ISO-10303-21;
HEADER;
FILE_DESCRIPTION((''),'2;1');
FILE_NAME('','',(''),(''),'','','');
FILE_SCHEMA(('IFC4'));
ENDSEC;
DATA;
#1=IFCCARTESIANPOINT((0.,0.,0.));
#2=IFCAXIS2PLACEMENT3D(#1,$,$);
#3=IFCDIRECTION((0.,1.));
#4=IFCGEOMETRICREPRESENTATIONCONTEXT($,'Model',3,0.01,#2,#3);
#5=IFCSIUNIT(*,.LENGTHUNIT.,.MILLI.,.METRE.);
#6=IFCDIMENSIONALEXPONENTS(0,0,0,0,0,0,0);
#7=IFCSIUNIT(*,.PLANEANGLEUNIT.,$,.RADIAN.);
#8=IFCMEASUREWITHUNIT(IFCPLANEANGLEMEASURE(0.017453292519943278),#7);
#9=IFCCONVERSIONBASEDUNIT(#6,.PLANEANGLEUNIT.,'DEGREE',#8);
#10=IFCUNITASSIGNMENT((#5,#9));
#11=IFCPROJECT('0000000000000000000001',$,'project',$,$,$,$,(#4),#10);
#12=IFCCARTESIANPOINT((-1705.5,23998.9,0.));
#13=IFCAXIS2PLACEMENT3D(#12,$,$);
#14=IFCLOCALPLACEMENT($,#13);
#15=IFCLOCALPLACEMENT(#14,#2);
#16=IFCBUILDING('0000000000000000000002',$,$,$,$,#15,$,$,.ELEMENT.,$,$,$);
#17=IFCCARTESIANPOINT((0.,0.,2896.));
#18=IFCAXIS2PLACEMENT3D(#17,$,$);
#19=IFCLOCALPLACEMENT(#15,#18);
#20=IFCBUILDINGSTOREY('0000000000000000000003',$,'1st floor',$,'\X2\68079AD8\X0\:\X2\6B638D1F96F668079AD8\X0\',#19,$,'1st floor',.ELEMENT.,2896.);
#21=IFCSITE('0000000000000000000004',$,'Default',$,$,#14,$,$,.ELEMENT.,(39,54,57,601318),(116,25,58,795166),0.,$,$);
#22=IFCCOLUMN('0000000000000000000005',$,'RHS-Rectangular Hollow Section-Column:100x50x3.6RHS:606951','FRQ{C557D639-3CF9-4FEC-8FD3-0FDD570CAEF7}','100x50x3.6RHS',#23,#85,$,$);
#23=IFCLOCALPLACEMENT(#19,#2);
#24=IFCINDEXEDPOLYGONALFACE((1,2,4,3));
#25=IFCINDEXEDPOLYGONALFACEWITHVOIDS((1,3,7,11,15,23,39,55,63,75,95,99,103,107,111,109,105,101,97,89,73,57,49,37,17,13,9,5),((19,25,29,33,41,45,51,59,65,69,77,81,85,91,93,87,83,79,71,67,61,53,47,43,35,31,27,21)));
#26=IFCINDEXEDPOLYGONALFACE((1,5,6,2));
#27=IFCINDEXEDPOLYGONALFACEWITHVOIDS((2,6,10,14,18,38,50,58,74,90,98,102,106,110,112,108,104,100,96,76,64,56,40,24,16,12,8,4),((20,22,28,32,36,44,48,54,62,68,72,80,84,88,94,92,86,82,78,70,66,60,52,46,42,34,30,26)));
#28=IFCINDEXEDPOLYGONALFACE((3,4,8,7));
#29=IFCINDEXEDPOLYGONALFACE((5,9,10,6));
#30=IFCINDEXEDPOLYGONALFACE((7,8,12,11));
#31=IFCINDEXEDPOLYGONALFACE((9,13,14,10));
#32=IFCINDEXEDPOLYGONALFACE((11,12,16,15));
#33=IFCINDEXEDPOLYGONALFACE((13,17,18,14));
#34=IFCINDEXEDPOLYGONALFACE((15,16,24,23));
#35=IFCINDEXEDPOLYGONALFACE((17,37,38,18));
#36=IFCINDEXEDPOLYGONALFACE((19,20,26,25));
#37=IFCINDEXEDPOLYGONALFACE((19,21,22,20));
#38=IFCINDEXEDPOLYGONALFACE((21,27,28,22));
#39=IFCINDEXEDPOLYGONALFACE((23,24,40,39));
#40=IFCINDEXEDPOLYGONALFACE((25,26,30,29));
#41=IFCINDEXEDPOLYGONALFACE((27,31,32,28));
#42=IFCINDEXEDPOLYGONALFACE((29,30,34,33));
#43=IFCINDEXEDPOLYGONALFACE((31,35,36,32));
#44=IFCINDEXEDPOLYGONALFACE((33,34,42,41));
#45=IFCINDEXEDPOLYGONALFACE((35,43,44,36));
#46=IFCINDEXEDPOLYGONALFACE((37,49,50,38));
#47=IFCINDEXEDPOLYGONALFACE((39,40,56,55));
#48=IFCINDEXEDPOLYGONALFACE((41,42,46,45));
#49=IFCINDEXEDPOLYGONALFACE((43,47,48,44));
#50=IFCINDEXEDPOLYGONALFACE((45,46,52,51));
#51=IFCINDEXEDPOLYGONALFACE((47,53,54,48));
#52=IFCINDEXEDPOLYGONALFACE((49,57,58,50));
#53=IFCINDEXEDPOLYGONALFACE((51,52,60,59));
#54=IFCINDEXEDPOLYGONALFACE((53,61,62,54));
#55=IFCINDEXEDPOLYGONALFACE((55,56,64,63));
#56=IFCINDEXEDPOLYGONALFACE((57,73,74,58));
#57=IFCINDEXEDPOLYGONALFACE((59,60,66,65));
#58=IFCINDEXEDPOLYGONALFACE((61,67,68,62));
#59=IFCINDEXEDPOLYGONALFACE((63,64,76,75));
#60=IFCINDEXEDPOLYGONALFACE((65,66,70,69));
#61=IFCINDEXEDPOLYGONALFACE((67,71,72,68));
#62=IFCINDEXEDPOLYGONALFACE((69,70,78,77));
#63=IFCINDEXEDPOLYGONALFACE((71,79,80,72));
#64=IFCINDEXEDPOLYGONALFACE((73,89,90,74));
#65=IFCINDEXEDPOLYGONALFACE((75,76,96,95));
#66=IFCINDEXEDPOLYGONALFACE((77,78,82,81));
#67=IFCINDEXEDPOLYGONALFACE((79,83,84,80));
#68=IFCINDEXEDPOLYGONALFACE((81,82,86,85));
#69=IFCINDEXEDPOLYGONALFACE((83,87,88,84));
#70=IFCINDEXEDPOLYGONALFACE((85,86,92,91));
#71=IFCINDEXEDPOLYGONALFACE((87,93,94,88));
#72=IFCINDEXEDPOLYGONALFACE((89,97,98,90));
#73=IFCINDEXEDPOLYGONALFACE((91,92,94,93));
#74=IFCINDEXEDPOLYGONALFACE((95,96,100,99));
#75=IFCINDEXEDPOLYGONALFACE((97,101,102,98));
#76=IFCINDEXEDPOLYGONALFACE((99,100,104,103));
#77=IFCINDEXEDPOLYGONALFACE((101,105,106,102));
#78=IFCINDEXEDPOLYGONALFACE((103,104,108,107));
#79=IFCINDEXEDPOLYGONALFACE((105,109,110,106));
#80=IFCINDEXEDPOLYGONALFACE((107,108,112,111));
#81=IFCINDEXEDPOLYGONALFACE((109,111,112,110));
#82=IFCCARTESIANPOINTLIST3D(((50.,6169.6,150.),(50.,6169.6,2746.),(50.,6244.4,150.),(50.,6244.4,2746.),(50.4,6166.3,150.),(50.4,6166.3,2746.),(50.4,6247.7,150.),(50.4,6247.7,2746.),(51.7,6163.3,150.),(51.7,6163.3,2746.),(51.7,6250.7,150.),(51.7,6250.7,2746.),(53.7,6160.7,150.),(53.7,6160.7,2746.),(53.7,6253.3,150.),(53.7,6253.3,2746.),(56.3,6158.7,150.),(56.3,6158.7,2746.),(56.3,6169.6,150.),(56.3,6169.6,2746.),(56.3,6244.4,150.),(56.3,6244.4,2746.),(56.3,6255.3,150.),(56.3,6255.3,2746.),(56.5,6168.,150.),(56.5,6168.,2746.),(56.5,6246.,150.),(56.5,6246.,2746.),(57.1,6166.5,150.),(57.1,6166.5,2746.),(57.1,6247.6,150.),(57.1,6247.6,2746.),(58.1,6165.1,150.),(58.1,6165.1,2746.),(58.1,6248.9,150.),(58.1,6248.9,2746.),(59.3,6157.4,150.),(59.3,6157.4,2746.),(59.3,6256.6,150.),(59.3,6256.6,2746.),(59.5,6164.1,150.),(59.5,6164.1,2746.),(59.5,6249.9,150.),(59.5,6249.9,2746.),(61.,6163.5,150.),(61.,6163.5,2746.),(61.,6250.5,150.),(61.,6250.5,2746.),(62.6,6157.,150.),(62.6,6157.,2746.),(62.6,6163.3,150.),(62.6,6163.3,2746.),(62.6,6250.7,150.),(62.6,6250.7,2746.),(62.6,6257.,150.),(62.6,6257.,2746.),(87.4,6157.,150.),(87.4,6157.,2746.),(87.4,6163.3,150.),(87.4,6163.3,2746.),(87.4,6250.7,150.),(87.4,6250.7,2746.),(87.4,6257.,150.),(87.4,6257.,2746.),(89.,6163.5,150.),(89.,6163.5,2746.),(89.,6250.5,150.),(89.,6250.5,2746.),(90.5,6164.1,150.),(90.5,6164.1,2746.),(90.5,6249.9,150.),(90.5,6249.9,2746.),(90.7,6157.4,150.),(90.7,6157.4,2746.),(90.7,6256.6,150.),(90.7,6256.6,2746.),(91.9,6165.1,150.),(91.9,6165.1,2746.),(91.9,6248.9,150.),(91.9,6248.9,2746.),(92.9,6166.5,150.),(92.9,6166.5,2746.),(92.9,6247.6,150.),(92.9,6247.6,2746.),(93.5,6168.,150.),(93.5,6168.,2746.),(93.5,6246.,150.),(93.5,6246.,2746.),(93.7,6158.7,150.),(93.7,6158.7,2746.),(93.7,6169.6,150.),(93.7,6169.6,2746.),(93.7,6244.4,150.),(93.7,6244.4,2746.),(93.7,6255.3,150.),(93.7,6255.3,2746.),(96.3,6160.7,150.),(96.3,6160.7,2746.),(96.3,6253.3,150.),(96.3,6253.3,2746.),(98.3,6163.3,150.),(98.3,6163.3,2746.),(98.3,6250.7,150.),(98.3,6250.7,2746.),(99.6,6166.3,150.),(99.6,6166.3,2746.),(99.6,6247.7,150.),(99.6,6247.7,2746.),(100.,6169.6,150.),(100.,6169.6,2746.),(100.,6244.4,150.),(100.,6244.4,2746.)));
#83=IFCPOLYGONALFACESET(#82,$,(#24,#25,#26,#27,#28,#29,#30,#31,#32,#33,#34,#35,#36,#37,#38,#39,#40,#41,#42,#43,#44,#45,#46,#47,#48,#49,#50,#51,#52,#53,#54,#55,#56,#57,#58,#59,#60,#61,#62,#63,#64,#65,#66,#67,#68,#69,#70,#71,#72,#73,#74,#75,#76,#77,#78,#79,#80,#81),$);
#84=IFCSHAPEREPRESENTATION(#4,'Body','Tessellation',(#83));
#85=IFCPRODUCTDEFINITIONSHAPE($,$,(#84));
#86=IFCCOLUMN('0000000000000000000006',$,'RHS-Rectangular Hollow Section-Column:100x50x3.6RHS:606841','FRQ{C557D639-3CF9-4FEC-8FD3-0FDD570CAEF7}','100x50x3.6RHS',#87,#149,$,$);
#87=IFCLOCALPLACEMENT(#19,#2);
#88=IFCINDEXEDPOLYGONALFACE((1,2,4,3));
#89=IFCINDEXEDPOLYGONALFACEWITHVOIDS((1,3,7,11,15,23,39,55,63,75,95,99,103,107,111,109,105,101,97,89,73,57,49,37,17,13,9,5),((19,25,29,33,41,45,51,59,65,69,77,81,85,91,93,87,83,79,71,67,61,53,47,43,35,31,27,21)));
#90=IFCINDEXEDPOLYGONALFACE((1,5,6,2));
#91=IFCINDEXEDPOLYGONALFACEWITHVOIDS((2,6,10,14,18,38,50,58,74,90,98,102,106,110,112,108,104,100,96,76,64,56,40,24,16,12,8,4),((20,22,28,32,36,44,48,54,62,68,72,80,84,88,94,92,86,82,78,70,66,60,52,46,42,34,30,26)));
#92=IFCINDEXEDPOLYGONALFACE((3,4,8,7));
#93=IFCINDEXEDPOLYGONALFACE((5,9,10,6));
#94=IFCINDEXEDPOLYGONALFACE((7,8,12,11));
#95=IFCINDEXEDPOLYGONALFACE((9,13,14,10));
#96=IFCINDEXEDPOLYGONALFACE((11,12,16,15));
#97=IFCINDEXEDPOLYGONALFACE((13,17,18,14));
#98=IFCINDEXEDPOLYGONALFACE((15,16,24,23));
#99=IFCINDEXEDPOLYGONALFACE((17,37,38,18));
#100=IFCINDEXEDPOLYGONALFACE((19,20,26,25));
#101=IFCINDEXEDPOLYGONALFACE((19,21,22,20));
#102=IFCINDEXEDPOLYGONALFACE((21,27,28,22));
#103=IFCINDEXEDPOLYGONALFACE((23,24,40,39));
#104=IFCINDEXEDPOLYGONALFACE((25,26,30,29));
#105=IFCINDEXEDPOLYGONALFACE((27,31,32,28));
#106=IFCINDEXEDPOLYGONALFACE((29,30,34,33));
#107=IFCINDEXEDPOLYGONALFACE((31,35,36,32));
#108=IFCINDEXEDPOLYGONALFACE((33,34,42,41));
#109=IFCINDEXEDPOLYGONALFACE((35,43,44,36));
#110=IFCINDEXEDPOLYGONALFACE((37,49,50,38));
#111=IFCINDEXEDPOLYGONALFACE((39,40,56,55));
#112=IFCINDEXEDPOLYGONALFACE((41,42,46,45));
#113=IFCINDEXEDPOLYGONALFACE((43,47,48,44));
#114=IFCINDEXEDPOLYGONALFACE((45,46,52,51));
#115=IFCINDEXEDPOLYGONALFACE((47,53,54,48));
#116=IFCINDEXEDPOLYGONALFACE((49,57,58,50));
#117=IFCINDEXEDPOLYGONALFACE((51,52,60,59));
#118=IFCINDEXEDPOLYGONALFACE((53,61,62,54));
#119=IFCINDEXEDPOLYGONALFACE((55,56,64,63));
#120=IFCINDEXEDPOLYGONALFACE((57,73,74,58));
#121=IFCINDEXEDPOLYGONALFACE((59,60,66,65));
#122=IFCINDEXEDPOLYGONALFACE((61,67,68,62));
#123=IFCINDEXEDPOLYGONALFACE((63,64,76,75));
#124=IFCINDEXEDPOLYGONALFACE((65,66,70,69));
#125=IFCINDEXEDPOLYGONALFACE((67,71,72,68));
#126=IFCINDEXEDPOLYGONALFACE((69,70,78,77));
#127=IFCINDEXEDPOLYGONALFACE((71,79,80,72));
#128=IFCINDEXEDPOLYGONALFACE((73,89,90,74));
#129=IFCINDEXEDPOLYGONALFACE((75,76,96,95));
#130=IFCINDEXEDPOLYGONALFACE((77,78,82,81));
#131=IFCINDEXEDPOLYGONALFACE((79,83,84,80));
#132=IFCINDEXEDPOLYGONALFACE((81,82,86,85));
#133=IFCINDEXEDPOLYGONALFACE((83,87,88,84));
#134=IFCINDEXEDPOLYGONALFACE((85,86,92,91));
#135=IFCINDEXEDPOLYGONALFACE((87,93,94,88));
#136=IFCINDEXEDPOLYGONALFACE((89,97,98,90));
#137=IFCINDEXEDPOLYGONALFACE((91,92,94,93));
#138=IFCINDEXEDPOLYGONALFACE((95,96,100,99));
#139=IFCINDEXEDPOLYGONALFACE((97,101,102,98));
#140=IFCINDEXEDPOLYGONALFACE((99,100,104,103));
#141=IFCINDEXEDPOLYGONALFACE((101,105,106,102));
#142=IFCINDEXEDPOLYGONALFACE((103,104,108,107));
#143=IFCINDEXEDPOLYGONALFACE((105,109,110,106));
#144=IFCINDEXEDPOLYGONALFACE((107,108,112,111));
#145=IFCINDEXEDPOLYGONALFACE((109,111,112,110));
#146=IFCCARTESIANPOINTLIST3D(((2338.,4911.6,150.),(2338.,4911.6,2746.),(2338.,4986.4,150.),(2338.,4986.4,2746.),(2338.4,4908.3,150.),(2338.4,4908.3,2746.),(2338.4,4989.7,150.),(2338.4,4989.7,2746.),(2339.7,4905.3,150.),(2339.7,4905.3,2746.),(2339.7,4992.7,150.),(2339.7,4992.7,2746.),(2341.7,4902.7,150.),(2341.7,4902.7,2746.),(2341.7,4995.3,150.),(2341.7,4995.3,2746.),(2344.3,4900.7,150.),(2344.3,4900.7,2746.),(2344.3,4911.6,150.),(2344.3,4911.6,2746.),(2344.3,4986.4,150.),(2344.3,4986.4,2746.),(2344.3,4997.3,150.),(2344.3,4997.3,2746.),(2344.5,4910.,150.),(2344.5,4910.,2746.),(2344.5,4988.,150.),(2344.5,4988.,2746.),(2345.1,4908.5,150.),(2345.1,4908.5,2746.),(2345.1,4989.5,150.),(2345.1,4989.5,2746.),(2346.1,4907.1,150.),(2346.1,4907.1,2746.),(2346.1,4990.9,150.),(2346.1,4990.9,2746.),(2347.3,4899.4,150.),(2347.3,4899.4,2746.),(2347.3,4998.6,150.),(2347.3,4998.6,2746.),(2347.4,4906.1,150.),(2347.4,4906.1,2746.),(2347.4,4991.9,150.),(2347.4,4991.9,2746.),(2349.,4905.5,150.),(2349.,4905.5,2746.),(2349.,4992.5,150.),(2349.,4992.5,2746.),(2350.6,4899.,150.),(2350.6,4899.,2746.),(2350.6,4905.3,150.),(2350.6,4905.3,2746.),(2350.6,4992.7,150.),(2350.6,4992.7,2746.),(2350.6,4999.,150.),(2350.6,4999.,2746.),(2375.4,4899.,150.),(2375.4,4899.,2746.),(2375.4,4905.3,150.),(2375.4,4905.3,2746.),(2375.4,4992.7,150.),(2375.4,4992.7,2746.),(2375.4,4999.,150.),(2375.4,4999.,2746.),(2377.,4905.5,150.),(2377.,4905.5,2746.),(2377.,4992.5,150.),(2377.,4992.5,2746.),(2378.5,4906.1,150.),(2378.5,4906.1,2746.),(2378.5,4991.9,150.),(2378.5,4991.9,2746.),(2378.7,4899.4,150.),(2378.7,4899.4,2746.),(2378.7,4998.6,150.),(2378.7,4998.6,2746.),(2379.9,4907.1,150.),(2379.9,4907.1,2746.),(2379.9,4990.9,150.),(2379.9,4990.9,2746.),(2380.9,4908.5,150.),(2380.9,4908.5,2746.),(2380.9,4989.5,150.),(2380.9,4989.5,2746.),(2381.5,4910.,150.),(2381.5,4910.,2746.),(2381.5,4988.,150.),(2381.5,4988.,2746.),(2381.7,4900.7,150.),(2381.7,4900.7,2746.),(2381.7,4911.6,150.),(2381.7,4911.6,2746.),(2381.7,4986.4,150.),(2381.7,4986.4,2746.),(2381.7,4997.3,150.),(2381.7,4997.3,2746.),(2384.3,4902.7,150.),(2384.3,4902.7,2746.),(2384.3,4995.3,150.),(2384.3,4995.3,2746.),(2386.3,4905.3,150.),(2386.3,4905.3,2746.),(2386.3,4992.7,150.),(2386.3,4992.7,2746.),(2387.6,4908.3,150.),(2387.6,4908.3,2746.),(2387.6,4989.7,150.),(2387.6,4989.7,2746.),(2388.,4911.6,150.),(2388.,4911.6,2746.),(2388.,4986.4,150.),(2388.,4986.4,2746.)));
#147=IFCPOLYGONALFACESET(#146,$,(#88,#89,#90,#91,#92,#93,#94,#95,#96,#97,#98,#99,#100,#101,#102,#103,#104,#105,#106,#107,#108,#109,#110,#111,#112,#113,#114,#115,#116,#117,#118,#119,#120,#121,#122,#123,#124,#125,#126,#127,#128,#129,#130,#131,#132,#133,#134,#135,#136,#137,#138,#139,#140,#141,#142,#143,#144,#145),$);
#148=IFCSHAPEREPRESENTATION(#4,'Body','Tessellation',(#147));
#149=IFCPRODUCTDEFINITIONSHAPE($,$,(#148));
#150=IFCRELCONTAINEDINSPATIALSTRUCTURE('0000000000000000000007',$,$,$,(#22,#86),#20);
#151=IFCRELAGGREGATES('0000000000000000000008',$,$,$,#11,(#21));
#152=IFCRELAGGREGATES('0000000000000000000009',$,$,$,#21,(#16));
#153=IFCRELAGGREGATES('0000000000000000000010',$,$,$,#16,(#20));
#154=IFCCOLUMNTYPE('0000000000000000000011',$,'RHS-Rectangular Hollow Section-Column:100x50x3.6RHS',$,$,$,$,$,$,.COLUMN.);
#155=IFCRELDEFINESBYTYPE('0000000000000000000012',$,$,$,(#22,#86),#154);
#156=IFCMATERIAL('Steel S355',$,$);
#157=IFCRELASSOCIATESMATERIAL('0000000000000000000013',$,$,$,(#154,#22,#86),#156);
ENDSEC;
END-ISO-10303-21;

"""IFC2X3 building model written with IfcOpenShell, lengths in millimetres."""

from ifc_helpers import new_model, entity, si_unit, converted_unit, direction, frame, origin, origin_2d, place, context, project, spatial, hollow_rectangle, extrude, clip, halfspace, material, type_object, element, save


model = new_model("IFC2X3")

# Units and contexts
model_context = context("Model", 3, precision=0.01, world=origin(), true_north=direction((0.0, 1.0)))
ifc_project = project(units=[si_unit("LENGTHUNIT", "METRE", prefix="MILLI"), converted_unit("PLANEANGLEUNIT", "DEGREE", entity("IfcPlaneAngleMeasure", 0.017453292519943278), si_unit("PLANEANGLEUNIT", "RADIAN"), dimensions=[0, 0, 0, 0, 0, 0, 0])], contexts=[model_context])

# Site, building, storey
site_placement = place(None, frame((-1705.5, 23998.9, 0.0)))
site = spatial("IfcSite", under=ifc_project, at=site_placement, Name="Default", CompositionType="ELEMENT", RefLatitude=(39, 54, 57, 601318), RefLongitude=(116, 25, 58, 795166), RefElevation=0.0)
building_placement = place(site_placement, origin())
building = spatial("IfcBuilding", under=site, at=building_placement, CompositionType="ELEMENT")
storey_placement = place(building_placement, frame((0.0, 0.0, 2896.0)))
storey = spatial("IfcBuildingStorey", under=building, at=storey_placement, Name="1st floor", ObjectType="标高:正负零标高", LongName="1st floor", CompositionType="ELEMENT", Elevation=2896.0)

# Columns
ifc_material_1 = material(Name="Steel S355")
column_type_1 = type_object("IfcColumnType", Name="RHS-Rectangular Hollow Section-Column:100x50x3.6RHS", PredefinedType="COLUMN", material=ifc_material_1)
column_1_placement = place(storey_placement, frame((75.0, 6207.0, 2746.0), z_axis=(0.0, 0.0, 1.0), x_axis=(-1.0, 0.0, 0.0)))
element("IfcColumn", 1, at=column_1_placement, inside=storey, type_object=column_type_1, material=ifc_material_1, Name="RHS-Rectangular Hollow Section-Column:100x50x3.6RHS:606951", Description="FRQ{C557D639-3CF9-4FEC-8FD3-0FDD570CAEF7}", ObjectType="100x50x3.6RHS", context=model_context, shape_type="Clipping", body=[
    clip(extrude(hollow_rectangle(XDim=50.0, YDim=100.0, WallThickness=6.3, InnerFilletRadius=6.3, OuterFilletRadius=12.6, at=origin_2d()), origin(), (0.0, 0.0, -1.0), 2651.9), halfspace(frame((75.0, 6207.0, -2596.0), z_axis=(0.0, 0.0, 1.0), x_axis=(-1.0, 0.0, 0.0)), True)),
])
column_2_placement = place(storey_placement, frame((2363.0, 4949.0, 2746.0), z_axis=(0.0, 0.0, 1.0), x_axis=(-1.0, 0.0, 0.0)))
element("IfcColumn", 2, at=column_2_placement, inside=storey, type_object=column_type_1, material=ifc_material_1, Name="RHS-Rectangular Hollow Section-Column:100x50x3.6RHS:606841", Description="FRQ{C557D639-3CF9-4FEC-8FD3-0FDD570CAEF7}", ObjectType="100x50x3.6RHS", context=model_context, shape_type="Clipping", body=[
    clip(extrude(hollow_rectangle(XDim=50.0, YDim=100.0, WallThickness=6.3, InnerFilletRadius=6.3, OuterFilletRadius=12.6, at=origin_2d()), origin(), (0.0, 0.0, -1.0), 2651.9), halfspace(frame((2363.0, 4949.0, -2596.0), z_axis=(0.0, 0.0, 1.0), x_axis=(-1.0, 0.0, 0.0)), True)),
])

save(model, "model.ifc")
